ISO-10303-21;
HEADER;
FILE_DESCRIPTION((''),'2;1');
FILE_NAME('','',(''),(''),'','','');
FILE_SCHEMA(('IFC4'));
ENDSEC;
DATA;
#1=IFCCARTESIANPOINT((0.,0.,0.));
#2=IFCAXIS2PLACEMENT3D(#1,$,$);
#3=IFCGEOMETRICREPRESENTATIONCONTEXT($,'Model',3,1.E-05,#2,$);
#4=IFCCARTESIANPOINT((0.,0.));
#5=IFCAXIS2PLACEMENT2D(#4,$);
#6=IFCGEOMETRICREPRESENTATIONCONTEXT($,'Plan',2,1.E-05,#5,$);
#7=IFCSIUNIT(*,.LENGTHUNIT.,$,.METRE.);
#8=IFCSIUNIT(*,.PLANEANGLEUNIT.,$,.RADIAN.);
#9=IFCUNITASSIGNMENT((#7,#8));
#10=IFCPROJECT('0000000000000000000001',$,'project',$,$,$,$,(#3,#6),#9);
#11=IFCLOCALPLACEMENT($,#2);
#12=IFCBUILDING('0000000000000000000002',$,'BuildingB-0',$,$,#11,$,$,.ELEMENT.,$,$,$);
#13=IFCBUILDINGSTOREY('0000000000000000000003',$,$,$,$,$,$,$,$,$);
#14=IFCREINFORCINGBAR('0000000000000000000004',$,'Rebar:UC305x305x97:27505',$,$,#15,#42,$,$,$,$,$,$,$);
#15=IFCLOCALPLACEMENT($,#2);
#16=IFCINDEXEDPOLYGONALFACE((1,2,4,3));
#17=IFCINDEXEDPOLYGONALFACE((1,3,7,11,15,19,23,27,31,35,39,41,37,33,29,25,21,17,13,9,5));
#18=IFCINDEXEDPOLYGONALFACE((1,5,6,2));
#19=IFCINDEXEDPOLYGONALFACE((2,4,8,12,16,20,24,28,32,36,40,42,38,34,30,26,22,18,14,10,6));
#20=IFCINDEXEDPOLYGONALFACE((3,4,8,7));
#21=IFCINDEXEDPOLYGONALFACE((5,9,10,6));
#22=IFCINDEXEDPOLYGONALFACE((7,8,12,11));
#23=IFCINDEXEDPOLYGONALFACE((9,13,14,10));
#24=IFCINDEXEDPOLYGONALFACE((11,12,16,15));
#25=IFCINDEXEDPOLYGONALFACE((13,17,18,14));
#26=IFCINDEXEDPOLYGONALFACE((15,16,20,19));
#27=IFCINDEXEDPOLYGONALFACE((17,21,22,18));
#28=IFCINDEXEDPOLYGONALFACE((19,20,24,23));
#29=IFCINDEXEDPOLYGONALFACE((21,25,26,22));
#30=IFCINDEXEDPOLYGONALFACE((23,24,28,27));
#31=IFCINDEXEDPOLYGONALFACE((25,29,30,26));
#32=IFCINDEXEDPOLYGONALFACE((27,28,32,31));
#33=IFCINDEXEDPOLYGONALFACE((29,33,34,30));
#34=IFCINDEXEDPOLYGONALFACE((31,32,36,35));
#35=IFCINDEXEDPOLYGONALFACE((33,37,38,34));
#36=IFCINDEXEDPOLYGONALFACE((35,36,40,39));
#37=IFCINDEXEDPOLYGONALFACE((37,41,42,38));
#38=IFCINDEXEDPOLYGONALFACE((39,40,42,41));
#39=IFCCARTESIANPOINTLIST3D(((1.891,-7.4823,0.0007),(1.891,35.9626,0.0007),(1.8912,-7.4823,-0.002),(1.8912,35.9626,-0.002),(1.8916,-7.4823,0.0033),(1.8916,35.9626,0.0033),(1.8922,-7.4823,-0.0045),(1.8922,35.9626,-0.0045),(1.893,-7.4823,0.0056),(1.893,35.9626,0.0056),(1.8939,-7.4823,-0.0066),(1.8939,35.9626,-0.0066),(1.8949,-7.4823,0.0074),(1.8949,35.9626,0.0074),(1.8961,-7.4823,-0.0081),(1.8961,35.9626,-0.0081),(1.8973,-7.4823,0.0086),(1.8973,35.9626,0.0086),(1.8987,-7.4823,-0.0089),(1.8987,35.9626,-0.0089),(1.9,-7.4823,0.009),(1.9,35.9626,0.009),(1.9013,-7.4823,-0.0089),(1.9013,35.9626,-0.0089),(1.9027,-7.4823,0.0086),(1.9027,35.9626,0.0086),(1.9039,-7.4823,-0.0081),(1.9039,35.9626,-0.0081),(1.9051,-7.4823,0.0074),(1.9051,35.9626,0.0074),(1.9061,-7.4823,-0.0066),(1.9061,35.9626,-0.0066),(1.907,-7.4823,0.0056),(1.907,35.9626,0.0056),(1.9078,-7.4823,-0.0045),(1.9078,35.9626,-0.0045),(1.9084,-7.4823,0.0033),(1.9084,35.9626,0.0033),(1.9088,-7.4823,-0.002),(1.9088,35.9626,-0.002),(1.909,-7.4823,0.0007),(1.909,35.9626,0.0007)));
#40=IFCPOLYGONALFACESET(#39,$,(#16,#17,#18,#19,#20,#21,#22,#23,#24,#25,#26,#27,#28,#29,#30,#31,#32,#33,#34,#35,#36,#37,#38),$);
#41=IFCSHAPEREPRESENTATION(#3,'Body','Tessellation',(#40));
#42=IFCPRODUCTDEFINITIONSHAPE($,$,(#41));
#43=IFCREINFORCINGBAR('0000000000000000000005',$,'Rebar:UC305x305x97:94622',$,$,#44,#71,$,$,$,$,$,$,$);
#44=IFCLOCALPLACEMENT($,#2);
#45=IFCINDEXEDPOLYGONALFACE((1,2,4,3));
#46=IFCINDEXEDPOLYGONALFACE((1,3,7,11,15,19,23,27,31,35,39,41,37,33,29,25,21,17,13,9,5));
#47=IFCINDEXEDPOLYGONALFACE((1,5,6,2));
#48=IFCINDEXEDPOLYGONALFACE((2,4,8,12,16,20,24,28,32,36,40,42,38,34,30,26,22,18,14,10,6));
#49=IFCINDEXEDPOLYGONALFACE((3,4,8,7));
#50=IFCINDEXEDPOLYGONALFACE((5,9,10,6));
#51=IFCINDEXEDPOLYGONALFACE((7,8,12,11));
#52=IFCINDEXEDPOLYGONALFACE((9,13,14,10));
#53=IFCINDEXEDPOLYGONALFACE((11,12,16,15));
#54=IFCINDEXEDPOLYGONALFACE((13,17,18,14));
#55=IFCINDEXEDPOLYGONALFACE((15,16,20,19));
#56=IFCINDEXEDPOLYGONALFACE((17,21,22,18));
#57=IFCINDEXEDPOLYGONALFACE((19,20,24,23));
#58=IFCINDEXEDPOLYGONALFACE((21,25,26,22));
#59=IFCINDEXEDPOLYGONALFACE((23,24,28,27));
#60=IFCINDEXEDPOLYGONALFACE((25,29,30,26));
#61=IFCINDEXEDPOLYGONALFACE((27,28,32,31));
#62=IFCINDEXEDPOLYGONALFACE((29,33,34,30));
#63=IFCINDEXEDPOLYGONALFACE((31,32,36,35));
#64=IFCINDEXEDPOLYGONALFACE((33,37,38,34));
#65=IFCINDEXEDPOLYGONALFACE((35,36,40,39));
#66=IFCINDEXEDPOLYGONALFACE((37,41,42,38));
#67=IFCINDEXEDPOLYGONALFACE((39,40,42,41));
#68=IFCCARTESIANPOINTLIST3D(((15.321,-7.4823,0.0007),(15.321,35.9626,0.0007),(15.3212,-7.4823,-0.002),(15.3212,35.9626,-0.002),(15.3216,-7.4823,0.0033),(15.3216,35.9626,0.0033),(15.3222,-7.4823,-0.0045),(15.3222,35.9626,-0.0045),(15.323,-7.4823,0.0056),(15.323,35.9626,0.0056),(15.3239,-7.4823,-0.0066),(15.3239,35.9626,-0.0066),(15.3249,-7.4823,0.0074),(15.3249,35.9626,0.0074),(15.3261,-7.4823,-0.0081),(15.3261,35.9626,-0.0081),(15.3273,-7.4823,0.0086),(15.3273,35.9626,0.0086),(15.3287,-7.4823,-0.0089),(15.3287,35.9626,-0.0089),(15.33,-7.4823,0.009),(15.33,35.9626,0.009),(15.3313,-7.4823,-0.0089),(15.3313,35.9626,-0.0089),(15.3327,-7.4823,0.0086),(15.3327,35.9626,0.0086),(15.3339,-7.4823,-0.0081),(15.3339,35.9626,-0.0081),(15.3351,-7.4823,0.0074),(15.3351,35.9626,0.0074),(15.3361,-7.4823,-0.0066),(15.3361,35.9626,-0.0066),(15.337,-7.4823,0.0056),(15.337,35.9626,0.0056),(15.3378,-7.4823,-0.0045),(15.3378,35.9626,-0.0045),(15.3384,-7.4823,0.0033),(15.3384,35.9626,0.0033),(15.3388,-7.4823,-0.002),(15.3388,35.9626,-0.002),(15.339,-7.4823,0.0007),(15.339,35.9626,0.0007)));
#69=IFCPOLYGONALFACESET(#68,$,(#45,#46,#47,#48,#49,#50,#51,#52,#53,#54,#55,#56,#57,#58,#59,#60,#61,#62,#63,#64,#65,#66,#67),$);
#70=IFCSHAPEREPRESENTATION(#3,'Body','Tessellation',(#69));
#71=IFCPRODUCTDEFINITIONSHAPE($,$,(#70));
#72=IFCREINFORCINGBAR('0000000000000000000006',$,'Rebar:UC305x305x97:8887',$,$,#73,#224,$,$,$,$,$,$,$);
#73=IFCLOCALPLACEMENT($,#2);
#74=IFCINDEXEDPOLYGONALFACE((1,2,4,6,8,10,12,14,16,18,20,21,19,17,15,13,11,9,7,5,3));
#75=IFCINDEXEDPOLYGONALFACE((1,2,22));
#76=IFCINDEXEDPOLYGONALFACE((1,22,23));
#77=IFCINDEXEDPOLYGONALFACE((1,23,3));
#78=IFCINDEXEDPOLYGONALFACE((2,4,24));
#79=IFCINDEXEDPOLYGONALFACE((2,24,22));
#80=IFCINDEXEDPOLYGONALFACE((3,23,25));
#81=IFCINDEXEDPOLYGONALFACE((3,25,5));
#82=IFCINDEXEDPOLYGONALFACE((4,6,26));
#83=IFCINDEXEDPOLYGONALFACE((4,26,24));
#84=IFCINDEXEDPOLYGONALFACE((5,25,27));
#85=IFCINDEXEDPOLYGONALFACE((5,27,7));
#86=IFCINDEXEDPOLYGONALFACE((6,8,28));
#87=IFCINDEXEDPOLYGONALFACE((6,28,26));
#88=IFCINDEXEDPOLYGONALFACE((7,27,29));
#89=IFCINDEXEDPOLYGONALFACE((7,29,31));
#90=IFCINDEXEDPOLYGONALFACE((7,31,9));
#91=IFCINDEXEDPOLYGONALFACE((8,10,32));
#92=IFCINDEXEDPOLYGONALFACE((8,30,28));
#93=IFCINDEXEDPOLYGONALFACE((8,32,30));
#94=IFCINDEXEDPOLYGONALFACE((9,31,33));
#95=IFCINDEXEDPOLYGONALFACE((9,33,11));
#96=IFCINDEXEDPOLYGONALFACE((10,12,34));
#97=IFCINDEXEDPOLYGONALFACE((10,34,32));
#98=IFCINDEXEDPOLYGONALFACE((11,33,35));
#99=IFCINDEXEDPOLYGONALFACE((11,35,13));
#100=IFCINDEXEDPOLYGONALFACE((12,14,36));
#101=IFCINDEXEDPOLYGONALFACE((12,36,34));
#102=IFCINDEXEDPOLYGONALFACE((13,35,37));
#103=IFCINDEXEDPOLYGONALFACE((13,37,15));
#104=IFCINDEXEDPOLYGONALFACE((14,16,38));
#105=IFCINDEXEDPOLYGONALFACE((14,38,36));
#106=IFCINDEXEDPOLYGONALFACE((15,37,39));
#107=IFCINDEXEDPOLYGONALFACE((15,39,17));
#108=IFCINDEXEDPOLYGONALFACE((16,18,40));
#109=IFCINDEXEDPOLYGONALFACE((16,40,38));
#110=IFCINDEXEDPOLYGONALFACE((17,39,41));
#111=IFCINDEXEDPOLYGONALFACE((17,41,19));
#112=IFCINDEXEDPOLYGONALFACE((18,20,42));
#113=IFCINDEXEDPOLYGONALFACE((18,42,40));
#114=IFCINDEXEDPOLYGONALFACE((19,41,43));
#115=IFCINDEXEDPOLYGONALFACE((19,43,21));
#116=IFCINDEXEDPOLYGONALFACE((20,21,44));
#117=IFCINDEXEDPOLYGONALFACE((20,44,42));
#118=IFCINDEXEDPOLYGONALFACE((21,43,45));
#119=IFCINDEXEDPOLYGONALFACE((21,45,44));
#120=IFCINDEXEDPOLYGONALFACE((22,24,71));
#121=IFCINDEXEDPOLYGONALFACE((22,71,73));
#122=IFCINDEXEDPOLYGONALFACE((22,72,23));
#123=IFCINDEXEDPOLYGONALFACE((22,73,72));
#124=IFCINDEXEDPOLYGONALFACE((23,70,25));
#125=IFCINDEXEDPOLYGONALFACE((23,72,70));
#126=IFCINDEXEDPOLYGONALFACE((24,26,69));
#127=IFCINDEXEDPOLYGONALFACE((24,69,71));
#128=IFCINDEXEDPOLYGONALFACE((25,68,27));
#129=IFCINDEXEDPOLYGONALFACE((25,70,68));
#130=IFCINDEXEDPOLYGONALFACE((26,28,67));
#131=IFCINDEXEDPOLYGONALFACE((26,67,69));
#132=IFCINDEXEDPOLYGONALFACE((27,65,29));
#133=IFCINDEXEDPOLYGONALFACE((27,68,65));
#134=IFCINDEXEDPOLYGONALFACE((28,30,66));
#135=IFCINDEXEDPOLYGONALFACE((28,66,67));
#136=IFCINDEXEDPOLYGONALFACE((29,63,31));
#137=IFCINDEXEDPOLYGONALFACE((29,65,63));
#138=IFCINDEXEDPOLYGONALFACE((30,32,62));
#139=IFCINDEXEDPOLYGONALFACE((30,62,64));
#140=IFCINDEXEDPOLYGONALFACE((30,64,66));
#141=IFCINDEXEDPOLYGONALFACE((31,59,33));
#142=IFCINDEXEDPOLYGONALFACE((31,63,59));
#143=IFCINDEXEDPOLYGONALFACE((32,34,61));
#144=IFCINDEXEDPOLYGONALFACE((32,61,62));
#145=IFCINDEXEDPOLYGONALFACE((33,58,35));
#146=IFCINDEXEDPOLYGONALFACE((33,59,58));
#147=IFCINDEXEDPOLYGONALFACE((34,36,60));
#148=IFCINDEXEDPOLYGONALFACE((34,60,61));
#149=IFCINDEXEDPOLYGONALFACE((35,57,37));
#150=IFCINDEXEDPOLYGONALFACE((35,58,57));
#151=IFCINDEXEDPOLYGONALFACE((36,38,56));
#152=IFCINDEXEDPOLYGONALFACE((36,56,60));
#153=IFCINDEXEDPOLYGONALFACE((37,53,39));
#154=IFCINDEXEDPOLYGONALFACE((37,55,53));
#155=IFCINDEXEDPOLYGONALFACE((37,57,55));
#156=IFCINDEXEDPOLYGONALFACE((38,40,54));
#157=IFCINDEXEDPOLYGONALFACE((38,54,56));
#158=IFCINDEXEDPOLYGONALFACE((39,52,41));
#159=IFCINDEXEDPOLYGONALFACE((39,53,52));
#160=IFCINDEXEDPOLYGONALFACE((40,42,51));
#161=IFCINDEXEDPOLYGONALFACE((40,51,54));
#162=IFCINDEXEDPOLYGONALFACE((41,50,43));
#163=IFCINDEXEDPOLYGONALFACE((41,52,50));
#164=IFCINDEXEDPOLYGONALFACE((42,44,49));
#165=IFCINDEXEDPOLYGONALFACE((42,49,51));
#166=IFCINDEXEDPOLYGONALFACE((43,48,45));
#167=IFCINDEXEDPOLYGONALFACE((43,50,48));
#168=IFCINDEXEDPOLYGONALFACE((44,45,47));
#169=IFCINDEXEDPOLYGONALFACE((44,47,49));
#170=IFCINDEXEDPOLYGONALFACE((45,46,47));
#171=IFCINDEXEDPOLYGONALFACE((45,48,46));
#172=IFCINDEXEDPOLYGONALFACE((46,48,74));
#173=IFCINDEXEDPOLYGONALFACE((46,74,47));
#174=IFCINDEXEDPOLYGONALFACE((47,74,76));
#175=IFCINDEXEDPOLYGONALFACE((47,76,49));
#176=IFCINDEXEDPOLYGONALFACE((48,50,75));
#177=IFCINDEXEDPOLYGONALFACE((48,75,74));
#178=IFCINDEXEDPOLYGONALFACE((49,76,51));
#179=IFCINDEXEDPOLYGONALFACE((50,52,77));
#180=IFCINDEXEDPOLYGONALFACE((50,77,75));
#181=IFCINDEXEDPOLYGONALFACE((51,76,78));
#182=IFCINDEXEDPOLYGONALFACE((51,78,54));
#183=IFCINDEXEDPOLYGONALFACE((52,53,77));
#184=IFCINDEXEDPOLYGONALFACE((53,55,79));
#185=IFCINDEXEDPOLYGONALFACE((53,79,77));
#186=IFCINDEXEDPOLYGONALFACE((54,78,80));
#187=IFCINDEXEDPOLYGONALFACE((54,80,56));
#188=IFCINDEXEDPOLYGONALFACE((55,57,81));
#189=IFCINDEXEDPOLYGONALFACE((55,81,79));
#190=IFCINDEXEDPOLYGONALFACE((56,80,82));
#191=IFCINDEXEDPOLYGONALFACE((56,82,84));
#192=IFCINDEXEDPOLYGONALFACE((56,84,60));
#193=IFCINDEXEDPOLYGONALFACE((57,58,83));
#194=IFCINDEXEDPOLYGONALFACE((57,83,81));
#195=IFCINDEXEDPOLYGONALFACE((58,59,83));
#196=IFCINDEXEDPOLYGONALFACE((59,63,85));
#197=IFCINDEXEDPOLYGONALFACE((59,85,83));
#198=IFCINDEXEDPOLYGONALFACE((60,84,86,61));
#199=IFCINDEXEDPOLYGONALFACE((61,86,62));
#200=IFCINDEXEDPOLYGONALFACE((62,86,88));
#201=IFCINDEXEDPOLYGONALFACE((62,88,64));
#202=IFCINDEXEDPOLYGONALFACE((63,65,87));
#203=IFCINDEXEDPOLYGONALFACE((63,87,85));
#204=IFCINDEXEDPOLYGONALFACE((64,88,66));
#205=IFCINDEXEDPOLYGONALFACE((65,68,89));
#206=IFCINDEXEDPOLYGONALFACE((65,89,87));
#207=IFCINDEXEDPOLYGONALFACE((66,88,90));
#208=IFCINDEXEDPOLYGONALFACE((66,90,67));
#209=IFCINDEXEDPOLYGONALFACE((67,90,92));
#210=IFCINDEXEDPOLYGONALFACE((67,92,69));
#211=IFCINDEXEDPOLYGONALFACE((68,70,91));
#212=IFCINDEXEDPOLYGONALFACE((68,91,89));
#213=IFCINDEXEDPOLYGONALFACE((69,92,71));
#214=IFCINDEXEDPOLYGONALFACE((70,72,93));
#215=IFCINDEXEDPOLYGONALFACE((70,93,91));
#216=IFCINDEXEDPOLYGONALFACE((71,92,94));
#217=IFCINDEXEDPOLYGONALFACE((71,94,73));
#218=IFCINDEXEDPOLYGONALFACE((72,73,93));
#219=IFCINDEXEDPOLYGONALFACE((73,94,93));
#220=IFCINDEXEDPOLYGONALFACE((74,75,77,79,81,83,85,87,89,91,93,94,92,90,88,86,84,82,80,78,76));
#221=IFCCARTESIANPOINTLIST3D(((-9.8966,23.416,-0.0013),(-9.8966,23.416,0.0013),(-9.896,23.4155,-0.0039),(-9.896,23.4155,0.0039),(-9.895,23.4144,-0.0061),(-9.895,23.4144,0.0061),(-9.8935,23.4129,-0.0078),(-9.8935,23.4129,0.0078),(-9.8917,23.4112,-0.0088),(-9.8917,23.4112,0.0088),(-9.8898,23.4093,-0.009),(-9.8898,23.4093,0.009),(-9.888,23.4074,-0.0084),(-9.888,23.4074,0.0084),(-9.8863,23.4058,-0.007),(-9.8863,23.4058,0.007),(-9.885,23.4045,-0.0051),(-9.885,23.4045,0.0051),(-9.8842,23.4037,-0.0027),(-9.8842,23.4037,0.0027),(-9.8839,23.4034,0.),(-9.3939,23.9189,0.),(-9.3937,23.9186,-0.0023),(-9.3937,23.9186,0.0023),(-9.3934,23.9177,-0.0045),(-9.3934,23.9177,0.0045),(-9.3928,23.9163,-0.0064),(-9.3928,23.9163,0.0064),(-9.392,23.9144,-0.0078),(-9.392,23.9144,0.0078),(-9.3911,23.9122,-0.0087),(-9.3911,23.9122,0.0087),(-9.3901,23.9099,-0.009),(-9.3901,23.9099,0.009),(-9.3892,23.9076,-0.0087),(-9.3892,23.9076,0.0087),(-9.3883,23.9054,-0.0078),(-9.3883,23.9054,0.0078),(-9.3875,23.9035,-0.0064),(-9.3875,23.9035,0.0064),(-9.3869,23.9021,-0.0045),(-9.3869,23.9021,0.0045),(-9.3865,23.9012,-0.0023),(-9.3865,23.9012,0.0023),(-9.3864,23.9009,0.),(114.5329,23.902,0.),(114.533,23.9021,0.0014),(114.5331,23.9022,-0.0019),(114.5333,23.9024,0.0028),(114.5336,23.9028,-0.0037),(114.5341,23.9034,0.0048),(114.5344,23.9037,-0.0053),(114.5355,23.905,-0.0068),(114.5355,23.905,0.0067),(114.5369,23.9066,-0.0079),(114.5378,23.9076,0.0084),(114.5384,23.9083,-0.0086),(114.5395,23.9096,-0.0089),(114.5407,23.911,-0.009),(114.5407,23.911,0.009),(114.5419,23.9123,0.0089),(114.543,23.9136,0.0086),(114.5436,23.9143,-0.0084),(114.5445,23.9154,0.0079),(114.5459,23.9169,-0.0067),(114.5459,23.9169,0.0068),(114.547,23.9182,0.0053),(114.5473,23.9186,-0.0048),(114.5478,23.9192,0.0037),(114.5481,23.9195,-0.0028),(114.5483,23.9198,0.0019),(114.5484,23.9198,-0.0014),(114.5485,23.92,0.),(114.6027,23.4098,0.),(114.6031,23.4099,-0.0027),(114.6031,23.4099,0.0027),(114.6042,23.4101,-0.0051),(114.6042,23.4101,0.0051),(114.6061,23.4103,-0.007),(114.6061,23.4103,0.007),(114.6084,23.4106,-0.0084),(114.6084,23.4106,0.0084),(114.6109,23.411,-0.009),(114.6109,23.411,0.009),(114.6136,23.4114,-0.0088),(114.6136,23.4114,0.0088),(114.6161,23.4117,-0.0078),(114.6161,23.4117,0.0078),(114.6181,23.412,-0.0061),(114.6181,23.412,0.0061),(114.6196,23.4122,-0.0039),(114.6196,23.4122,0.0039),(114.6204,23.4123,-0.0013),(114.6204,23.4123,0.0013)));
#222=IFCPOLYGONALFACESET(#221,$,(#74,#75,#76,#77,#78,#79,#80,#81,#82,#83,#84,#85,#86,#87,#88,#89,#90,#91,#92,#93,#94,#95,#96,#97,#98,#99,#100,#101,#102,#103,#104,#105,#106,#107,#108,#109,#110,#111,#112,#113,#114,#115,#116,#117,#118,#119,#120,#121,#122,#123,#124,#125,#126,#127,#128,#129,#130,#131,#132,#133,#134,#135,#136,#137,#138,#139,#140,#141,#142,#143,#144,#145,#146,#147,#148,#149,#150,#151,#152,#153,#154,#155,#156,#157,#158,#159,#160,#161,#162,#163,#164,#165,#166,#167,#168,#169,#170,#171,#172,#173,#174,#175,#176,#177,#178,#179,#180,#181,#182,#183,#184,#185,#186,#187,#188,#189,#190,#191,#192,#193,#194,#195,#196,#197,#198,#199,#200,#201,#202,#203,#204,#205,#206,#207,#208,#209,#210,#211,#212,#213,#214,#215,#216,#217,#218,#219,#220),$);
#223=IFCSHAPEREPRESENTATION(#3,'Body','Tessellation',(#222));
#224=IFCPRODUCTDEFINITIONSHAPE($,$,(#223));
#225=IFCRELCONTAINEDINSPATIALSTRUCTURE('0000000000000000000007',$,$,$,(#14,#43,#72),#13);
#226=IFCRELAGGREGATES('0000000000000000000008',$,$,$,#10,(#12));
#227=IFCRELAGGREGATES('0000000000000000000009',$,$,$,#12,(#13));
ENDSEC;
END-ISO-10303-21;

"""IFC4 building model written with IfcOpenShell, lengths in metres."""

from ifc_helpers import new_model, entity, si_unit, origin, origin_2d, place, context, project, spatial, element, save


model = new_model("IFC4")

# Units and contexts
model_context = context("Model", 3, precision=1e-05, world=origin())
plan_context = context("Plan", 2, precision=1e-05, world=origin_2d())
ifc_project = project(units=[si_unit("LENGTHUNIT", "METRE"), si_unit("PLANEANGLEUNIT", "RADIAN")], contexts=[model_context, plan_context])

# Building, storey
building_placement = place(None, origin())
building = spatial("IfcBuilding", under=ifc_project, at=building_placement, Name="BuildingB-0", CompositionType="ELEMENT")
storey = spatial("IfcBuildingStorey", under=building)

# Reinforcing bars
element("IfcReinforcingBar", 1, inside=storey, Name="Rebar:UC305x305x97:27505", context=model_context, shape_type="SweptSolid", body=[
    entity("IfcSurfaceCurveSweptAreaSolid", entity("IfcCircleProfileDef", "AREA", None, None, 0.009), None, entity("IfcPolyline", [entity("IfcCartesianPoint", [1.9, 35.9626, 0.0]), entity("IfcCartesianPoint", [1.9, -7.4823, 0.0])]), None, None, entity("IfcPlane", entity("IfcAxis2Placement3D", entity("IfcCartesianPoint", [1.9, 35.9626, 0.0]), entity("IfcDirection", [0.0, 0.0, 1.0]), entity("IfcDirection", [1.0, 0.0, 0.0])))),
])
element("IfcReinforcingBar", 2, inside=storey, Name="Rebar:UC305x305x97:94622", context=model_context, shape_type="SweptSolid", body=[
    entity("IfcSurfaceCurveSweptAreaSolid", entity("IfcCircleProfileDef", "AREA", None, None, 0.009), None, entity("IfcPolyline", [entity("IfcCartesianPoint", [15.33, 35.9626, 0.0]), entity("IfcCartesianPoint", [15.33, -7.4823, 0.0])]), None, None, entity("IfcPlane", entity("IfcAxis2Placement3D", entity("IfcCartesianPoint", [15.33, 35.9626, 0.0]), entity("IfcDirection", [0.0, 0.0, 1.0]), entity("IfcDirection", [1.0, 0.0, 0.0])))),
])
element("IfcReinforcingBar", 3, inside=storey, Name="Rebar:UC305x305x97:8887", context=model_context, shape_type="SweptSolid", body=[
    entity("IfcSurfaceCurveSweptAreaSolid", entity("IfcCircleProfileDef", "AREA", None, None, 0.009), None, entity("IfcPolyline", [entity("IfcCartesianPoint", [-9.8903, 23.4097, 0.0]), entity("IfcCartesianPoint", [-9.3901, 23.9099, 0.0]), entity("IfcCartesianPoint", [114.5407, 23.911, 0.0]), entity("IfcCartesianPoint", [114.6116, 23.4111, 0.0])]), None, None, entity("IfcPlane", entity("IfcAxis2Placement3D", entity("IfcCartesianPoint", [-9.8903, 23.4097, 0.0]), entity("IfcDirection", [-0.000009, 1.0, 0.0]), entity("IfcDirection", [1.0, 0.000009, 0.0])))),
])

save(model, "model.ifc")
